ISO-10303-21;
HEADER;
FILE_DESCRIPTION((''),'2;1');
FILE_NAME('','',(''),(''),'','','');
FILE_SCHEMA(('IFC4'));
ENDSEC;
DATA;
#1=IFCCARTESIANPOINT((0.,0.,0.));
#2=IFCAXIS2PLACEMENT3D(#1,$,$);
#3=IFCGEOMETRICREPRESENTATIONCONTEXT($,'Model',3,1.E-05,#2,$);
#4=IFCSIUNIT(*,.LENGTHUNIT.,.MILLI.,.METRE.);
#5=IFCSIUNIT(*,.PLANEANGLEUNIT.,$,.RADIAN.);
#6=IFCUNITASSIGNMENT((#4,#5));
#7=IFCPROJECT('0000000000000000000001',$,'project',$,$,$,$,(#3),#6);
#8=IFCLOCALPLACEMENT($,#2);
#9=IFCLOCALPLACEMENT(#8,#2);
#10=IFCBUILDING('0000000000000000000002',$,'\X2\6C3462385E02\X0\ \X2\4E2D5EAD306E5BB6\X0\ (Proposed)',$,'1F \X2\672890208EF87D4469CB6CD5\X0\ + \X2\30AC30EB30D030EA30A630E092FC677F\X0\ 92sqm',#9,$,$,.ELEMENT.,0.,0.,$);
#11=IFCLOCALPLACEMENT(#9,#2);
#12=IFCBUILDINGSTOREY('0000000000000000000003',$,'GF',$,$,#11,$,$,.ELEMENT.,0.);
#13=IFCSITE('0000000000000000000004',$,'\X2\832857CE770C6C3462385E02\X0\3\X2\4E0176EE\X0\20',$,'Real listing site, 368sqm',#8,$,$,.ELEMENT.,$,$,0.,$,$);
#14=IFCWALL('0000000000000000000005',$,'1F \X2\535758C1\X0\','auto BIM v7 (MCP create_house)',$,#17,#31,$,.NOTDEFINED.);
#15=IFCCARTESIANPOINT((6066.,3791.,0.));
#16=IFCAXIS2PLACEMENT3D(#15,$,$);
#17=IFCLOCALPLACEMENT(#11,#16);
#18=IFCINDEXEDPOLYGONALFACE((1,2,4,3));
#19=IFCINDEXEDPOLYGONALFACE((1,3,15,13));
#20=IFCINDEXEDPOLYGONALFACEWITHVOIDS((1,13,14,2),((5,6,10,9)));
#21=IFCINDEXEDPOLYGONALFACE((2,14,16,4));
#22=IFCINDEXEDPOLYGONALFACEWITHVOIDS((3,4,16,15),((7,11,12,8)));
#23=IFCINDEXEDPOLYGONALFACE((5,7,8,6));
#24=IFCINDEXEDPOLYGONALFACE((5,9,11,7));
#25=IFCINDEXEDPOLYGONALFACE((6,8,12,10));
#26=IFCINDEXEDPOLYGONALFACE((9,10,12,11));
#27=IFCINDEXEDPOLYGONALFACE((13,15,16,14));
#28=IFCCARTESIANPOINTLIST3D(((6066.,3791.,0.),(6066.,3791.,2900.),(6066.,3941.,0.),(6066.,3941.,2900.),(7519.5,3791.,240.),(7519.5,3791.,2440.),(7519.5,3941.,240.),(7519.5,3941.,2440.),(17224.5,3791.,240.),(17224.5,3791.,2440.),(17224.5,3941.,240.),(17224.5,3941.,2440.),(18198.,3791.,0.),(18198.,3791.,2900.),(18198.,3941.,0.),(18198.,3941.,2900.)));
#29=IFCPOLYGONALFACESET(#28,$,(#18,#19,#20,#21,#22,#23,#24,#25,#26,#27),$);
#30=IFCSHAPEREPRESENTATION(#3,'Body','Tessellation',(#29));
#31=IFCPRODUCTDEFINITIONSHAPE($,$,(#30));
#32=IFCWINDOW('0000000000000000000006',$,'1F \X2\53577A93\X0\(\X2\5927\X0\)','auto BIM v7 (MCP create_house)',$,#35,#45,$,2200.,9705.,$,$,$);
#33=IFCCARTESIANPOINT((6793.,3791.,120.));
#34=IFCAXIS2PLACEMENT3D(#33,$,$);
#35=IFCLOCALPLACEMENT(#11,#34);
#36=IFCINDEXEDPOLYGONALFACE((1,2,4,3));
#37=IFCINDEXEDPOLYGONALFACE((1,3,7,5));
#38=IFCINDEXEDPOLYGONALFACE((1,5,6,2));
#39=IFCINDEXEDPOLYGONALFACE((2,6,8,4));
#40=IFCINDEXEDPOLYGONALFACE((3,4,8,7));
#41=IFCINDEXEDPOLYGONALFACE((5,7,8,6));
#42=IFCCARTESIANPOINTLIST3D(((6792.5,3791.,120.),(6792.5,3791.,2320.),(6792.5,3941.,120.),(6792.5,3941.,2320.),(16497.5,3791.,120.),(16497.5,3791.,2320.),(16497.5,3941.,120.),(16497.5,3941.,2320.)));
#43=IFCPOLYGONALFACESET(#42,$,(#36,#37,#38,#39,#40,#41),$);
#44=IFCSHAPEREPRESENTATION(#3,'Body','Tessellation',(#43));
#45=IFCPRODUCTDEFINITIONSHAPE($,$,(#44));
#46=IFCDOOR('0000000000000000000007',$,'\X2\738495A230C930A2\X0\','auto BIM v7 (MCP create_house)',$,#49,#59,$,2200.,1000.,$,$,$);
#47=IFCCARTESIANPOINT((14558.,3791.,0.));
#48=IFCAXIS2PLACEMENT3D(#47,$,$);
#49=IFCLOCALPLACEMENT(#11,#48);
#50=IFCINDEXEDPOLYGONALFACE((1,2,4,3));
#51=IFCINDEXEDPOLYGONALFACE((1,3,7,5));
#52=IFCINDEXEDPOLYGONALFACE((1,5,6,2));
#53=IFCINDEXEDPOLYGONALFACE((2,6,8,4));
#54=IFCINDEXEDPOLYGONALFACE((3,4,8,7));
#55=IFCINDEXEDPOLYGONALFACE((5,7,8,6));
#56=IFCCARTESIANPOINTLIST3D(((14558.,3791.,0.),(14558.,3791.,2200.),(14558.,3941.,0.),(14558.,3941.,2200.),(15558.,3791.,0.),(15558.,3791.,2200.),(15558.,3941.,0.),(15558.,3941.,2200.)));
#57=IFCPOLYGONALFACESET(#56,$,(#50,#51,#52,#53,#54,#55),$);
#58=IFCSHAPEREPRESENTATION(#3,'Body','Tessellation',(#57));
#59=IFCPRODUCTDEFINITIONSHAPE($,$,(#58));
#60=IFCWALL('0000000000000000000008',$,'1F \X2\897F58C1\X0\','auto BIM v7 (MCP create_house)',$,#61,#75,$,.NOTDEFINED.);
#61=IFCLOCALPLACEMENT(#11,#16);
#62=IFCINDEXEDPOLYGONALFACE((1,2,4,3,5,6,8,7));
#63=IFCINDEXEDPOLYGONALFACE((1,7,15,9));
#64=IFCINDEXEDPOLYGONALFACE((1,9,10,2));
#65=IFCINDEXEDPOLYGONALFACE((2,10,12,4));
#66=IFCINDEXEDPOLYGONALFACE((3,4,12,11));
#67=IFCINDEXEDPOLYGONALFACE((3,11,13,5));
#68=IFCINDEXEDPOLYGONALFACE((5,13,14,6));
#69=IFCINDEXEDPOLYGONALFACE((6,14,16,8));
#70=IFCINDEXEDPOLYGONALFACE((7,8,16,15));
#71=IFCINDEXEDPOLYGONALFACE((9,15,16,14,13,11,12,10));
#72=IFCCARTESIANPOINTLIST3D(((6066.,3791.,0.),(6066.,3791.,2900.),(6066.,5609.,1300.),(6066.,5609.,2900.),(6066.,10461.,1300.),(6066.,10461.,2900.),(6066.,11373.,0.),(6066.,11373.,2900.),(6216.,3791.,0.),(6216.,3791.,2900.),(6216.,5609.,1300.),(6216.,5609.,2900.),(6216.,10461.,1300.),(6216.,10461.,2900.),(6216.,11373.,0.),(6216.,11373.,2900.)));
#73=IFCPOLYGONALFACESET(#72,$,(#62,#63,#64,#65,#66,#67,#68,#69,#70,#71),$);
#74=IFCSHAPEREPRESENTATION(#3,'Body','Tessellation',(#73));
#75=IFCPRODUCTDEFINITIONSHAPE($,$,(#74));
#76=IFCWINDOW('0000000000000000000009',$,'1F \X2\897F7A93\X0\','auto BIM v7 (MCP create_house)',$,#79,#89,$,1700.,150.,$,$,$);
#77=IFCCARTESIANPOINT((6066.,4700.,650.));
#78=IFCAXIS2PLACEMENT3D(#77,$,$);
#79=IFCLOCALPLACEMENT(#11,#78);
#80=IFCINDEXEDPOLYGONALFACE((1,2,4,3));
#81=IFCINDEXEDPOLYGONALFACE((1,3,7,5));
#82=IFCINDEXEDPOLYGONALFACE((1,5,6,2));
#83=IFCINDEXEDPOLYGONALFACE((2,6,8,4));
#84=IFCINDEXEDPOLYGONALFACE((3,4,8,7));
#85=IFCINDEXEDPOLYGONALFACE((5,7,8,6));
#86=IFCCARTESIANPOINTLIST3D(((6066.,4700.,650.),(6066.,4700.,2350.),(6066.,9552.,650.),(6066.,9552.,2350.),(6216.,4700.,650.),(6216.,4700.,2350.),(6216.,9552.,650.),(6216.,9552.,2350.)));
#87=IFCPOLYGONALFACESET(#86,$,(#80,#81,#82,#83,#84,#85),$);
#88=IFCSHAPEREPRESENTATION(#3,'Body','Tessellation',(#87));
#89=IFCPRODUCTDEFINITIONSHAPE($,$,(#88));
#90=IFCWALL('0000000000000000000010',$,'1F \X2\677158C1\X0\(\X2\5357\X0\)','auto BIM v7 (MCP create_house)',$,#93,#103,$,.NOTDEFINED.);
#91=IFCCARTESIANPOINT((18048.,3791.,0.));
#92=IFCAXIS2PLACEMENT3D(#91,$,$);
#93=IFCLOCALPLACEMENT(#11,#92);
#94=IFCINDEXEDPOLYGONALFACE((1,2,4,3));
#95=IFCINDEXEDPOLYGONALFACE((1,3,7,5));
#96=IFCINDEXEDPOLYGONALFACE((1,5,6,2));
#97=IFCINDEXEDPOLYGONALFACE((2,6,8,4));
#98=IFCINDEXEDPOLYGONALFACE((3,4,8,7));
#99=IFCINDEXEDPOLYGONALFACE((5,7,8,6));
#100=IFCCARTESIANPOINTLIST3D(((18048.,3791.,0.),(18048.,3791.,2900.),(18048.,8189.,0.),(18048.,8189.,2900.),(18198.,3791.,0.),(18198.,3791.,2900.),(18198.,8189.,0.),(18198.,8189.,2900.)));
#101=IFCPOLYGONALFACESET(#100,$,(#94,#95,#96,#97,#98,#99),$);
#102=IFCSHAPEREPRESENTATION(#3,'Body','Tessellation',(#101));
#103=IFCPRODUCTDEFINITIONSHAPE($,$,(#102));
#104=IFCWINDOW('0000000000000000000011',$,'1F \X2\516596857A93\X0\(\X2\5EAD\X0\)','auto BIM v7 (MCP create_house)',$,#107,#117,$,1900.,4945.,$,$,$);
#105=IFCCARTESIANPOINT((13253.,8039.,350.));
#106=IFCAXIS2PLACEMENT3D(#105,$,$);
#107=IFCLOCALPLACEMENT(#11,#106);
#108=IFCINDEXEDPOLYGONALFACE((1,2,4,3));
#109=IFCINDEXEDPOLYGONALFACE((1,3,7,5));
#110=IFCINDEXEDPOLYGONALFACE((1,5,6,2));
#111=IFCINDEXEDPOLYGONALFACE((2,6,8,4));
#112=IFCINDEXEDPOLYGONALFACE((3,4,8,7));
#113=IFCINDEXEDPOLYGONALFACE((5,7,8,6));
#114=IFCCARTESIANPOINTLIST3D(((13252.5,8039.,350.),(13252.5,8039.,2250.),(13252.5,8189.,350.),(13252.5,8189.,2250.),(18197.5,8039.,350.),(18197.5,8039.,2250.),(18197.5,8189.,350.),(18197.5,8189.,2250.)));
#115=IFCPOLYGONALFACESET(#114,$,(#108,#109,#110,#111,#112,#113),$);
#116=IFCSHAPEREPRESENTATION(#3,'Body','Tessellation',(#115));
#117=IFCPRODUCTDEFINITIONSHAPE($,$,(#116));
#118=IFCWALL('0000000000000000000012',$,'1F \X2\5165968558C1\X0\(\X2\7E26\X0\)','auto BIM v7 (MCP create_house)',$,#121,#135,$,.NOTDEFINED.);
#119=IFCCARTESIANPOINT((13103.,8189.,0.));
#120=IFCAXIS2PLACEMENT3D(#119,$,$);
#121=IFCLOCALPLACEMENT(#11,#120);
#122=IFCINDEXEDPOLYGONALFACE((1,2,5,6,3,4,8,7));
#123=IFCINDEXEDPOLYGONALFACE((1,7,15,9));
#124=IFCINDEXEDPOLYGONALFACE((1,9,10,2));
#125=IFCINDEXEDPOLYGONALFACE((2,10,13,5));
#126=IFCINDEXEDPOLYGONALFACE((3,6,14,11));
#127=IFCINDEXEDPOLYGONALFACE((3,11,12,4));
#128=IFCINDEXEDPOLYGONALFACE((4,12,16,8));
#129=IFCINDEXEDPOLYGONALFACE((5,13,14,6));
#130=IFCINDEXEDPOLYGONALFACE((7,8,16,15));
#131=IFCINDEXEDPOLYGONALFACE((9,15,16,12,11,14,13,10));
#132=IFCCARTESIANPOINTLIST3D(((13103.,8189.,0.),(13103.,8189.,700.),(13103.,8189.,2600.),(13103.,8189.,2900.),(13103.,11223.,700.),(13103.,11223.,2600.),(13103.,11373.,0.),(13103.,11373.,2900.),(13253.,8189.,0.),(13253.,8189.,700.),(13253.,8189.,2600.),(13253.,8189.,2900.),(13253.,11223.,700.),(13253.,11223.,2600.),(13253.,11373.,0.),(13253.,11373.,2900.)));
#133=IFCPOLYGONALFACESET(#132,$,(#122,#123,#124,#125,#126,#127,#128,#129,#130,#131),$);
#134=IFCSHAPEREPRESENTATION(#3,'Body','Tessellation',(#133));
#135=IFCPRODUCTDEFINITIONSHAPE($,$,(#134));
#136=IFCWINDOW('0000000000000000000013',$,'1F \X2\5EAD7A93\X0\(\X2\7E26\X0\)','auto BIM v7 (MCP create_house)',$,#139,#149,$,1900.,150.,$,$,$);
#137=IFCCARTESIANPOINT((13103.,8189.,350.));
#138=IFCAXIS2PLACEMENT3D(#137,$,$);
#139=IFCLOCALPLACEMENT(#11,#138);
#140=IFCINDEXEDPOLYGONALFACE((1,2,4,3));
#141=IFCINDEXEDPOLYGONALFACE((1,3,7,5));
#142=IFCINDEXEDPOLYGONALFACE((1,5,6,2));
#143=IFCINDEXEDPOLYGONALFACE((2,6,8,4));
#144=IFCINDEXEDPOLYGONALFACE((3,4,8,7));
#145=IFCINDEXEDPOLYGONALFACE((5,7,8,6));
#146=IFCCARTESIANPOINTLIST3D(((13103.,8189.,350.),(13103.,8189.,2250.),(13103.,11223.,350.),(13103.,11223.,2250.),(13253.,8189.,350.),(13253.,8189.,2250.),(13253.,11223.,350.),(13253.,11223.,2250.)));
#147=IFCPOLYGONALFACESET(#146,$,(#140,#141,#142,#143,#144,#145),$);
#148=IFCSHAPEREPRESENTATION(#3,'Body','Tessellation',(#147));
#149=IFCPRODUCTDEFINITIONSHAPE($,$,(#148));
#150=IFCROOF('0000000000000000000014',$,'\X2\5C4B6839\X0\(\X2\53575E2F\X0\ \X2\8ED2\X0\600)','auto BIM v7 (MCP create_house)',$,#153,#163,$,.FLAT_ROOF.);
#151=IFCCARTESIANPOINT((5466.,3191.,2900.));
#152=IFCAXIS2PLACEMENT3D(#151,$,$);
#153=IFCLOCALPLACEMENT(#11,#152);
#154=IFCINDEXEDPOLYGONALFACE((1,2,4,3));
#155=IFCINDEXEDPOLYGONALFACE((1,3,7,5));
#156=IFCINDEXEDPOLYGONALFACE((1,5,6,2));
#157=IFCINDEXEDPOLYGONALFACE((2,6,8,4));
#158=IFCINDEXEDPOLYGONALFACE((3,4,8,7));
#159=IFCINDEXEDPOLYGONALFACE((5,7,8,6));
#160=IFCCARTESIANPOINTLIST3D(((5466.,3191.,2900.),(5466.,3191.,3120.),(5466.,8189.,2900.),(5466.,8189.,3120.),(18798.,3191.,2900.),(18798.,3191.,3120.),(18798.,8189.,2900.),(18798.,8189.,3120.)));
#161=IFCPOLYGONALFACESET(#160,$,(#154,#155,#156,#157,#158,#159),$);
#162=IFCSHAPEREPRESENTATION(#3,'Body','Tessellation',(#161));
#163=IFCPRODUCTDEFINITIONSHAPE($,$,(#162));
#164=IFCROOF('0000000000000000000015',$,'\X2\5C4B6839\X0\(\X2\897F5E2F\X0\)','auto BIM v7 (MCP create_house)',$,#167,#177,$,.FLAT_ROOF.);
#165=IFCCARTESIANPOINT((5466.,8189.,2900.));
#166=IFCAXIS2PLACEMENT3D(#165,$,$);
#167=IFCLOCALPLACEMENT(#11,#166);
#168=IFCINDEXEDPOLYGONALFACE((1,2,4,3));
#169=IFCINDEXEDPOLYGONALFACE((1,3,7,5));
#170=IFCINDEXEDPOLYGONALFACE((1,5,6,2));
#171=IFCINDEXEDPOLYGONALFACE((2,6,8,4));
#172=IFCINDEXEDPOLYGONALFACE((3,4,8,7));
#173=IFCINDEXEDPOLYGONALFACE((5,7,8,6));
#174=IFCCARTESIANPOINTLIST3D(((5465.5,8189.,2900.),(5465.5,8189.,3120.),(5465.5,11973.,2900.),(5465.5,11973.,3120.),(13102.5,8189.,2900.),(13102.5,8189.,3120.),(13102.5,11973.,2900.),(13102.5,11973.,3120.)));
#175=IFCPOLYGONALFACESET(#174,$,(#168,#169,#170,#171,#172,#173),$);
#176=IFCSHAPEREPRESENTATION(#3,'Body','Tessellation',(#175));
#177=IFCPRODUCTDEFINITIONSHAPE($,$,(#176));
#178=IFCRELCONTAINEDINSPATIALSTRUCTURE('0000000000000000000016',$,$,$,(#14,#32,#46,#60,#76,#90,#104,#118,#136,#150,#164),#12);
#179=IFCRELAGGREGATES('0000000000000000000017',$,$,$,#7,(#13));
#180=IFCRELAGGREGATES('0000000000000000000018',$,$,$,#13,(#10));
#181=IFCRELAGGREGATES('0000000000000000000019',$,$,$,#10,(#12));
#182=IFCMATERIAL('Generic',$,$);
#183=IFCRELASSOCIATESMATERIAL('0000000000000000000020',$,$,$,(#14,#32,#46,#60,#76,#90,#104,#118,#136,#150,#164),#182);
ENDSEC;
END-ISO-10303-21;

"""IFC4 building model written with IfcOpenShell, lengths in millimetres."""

from ifc_helpers import new_model, si_unit, frame, frame_2d, origin, place, context, project, spatial, rectangle, extrude, material, element, fill, save


model = new_model("IFC4")

# Units and contexts
model_context = context("Model", 3, precision=1e-05, world=origin())
ifc_project = project(units=[si_unit("LENGTHUNIT", "METRE", prefix="MILLI"), si_unit("PLANEANGLEUNIT", "RADIAN")], contexts=[model_context])

# Site, building, storey
site_placement = place(None, origin())
site = spatial("IfcSite", under=ifc_project, at=site_placement, Name="茨城県水戸市3丁目20", ObjectType="Real listing site, 368sqm", CompositionType="ELEMENT", RefElevation=0.0)
building_placement = place(site_placement, origin())
building = spatial("IfcBuilding", under=site, at=building_placement, Name="水戸市 中庭の家 (Proposed)", ObjectType="1F 木造軸組構法 + ガルバリウム鋼板 92sqm", CompositionType="ELEMENT", ElevationOfRefHeight=0.0, ElevationOfTerrain=0.0)
storey_placement = place(building_placement, origin())
storey = spatial("IfcBuildingStorey", under=building, at=storey_placement, Name="GF", CompositionType="ELEMENT", Elevation=0.0)

# Shared definitions
ifc_material = material(Name="Generic")

# Wall, openings, window, door
wall_1_placement = place(storey_placement, frame((6066.0, 3791.0, 0.0)))
wall_1 = element("IfcWall", 1, at=wall_1_placement, inside=storey, material=ifc_material, Name="1F 南壁", Description="auto BIM v7 (MCP create_house)", PredefinedType="NOTDEFINED", context=model_context, shape_type="SweptSolid", body=[
    extrude(rectangle(XDim=12132.0, YDim=150.0, at=frame_2d((6066.0, 75.0))), frame((6066.0, 3791.0, 0.0)), (0.0, 0.0, 1.0), 2900.0),
])
opening_1_placement = place(storey_placement, frame((6793.0, 3791.0, 120.0)))
opening_1 = element("IfcOpeningElement", 2, at=opening_1_placement, cuts=wall_1, PredefinedType="NOTDEFINED", context=model_context, shape_type="SweptSolid", body=[
    extrude(rectangle(XDim=9705.0, YDim=150.0, at=frame_2d((4852.0, 75.0))), frame((6793.0, 3791.0, 120.0)), (0.0, 0.0, 1.0), 2200.0),
])
opening_2_placement = place(storey_placement, frame((14558.0, 3791.0, 0.0)))
opening_2 = element("IfcOpeningElement", 3, at=opening_2_placement, cuts=wall_1, PredefinedType="NOTDEFINED", context=model_context, shape_type="SweptSolid", body=[
    extrude(rectangle(XDim=1000.0, YDim=150.0, at=frame_2d((500.0, 75.0))), frame((14558.0, 3791.0, 0.0)), (0.0, 0.0, 1.0), 2200.0),
])
window_1_placement = place(storey_placement, frame((6793.0, 3791.0, 120.0)))
window_1 = element("IfcWindow", 4, at=window_1_placement, inside=storey, material=ifc_material, Name="1F 南窓(大)", Description="auto BIM v7 (MCP create_house)", OverallHeight=2200.0, OverallWidth=9705.0, context=model_context, shape_type="SweptSolid", body=[
    extrude(rectangle(XDim=9705.0, YDim=150.0, at=frame_2d((4852.0, 75.0))), frame((6793.0, 3791.0, 120.0)), (0.0, 0.0, 1.0), 2200.0),
])
fill(opening_1, window_1)
door_placement = place(storey_placement, frame((14558.0, 3791.0, 0.0)))
door = element("IfcDoor", 5, at=door_placement, inside=storey, material=ifc_material, Name="玄関ドア", Description="auto BIM v7 (MCP create_house)", OverallHeight=2200.0, OverallWidth=1000.0, context=model_context, shape_type="SweptSolid", body=[
    extrude(rectangle(XDim=1000.0, YDim=150.0, at=frame_2d((500.0, 75.0))), frame((14558.0, 3791.0, 0.0)), (0.0, 0.0, 1.0), 2200.0),
])
fill(opening_2, door)

# Wall, opening, window
wall_2_placement = place(storey_placement, frame((6066.0, 3791.0, 0.0)))
wall_2 = element("IfcWall", 6, at=wall_2_placement, inside=storey, material=ifc_material, Name="1F 西壁", Description="auto BIM v7 (MCP create_house)", PredefinedType="NOTDEFINED", context=model_context, shape_type="SweptSolid", body=[
    extrude(rectangle(XDim=150.0, YDim=7582.0, at=frame_2d((75.0, 3791.0))), frame((6066.0, 3791.0, 0.0)), (0.0, 0.0, 1.0), 2900.0),
])
opening_3_placement = place(storey_placement, frame((6066.0, 4700.0, 650.0)))
opening_3 = element("IfcOpeningElement", 7, at=opening_3_placement, cuts=wall_2, PredefinedType="NOTDEFINED", context=model_context, shape_type="SweptSolid", body=[
    extrude(rectangle(XDim=150.0, YDim=4852.0, at=frame_2d((75.0, 2426.0))), frame((6066.0, 4700.0, 650.0)), (0.0, 0.0, 1.0), 1700.0),
])
window_2_placement = place(storey_placement, frame((6066.0, 4700.0, 650.0)))
window_2 = element("IfcWindow", 8, at=window_2_placement, inside=storey, material=ifc_material, Name="1F 西窓", Description="auto BIM v7 (MCP create_house)", OverallHeight=1700.0, OverallWidth=150.0, context=model_context, shape_type="SweptSolid", body=[
    extrude(rectangle(XDim=150.0, YDim=4852.0, at=frame_2d((75.0, 2426.0))), frame((6066.0, 4700.0, 650.0)), (0.0, 0.0, 1.0), 1700.0),
])
fill(opening_3, window_2)

# Wall, opening, window
wall_3_placement = place(storey_placement, frame((18048.0, 3791.0, 0.0)))
wall_3 = element("IfcWall", 9, at=wall_3_placement, inside=storey, material=ifc_material, Name="1F 東壁(南)", Description="auto BIM v7 (MCP create_house)", PredefinedType="NOTDEFINED", context=model_context, shape_type="SweptSolid", body=[
    extrude(rectangle(XDim=150.0, YDim=4398.0, at=frame_2d((75.0, 2199.0))), frame((18048.0, 3791.0, 0.0)), (0.0, 0.0, 1.0), 2900.0),
])
opening_4_placement = place(storey_placement, frame((13253.0, 8039.0, 350.0)))
opening_4 = element("IfcOpeningElement", 10, at=opening_4_placement, cuts=wall_3, PredefinedType="NOTDEFINED", context=model_context, shape_type="SweptSolid", body=[
    extrude(rectangle(XDim=4945.0, YDim=150.0, at=frame_2d((2472.0, 75.0))), frame((13253.0, 8039.0, 350.0)), (0.0, 0.0, 1.0), 1900.0),
])
window_3_placement = place(storey_placement, frame((13253.0, 8039.0, 350.0)))
window_3 = element("IfcWindow", 11, at=window_3_placement, inside=storey, material=ifc_material, Name="1F 入隅窓(庭)", Description="auto BIM v7 (MCP create_house)", OverallHeight=1900.0, OverallWidth=4945.0, context=model_context, shape_type="SweptSolid", body=[
    extrude(rectangle(XDim=4945.0, YDim=150.0, at=frame_2d((2472.0, 75.0))), frame((13253.0, 8039.0, 350.0)), (0.0, 0.0, 1.0), 1900.0),
])
fill(opening_4, window_3)

# Wall, opening, window
wall_4_placement = place(storey_placement, frame((13103.0, 8189.0, 0.0)))
wall_4 = element("IfcWall", 12, at=wall_4_placement, inside=storey, material=ifc_material, Name="1F 入隅壁(縦)", Description="auto BIM v7 (MCP create_house)", PredefinedType="NOTDEFINED", context=model_context, shape_type="SweptSolid", body=[
    extrude(rectangle(XDim=150.0, YDim=3184.0, at=frame_2d((75.0, 1592.0))), frame((13103.0, 8189.0, 0.0)), (0.0, 0.0, 1.0), 2900.0),
])
opening_5_placement = place(storey_placement, frame((13103.0, 8189.0, 350.0)))
opening_5 = element("IfcOpeningElement", 13, at=opening_5_placement, cuts=wall_4, PredefinedType="NOTDEFINED", context=model_context, shape_type="SweptSolid", body=[
    extrude(rectangle(XDim=150.0, YDim=3034.0, at=frame_2d((75.0, 1517.0))), frame((13103.0, 8189.0, 350.0)), (0.0, 0.0, 1.0), 1900.0),
])
window_4_placement = place(storey_placement, frame((13103.0, 8189.0, 350.0)))
window_4 = element("IfcWindow", 14, at=window_4_placement, inside=storey, material=ifc_material, Name="1F 庭窓(縦)", Description="auto BIM v7 (MCP create_house)", OverallHeight=1900.0, OverallWidth=150.0, context=model_context, shape_type="SweptSolid", body=[
    extrude(rectangle(XDim=150.0, YDim=3034.0, at=frame_2d((75.0, 1517.0))), frame((13103.0, 8189.0, 350.0)), (0.0, 0.0, 1.0), 1900.0),
])
fill(opening_5, window_4)

# Roofs
roof_1_placement = place(storey_placement, frame((5466.0, 3191.0, 2900.0)))
element("IfcRoof", 15, at=roof_1_placement, inside=storey, material=ifc_material, Name="屋根(南帯 軒600)", Description="auto BIM v7 (MCP create_house)", PredefinedType="FLAT_ROOF", context=model_context, shape_type="SweptSolid", body=[
    extrude(rectangle(XDim=13332.0, YDim=4998.0, at=frame_2d((6666.0, 2499.0))), frame((5466.0, 3191.0, 2900.0)), (0.0, 0.0, 1.0), 220.0),
])
roof_2_placement = place(storey_placement, frame((5466.0, 8189.0, 2900.0)))
element("IfcRoof", 16, at=roof_2_placement, inside=storey, material=ifc_material, Name="屋根(西帯)", Description="auto BIM v7 (MCP create_house)", PredefinedType="FLAT_ROOF", context=model_context, shape_type="SweptSolid", body=[
    extrude(rectangle(XDim=7637.0, YDim=3784.0, at=frame_2d((3818.0, 1892.0))), frame((5466.0, 8189.0, 2900.0)), (0.0, 0.0, 1.0), 220.0),
])

save(model, "model.ifc")
